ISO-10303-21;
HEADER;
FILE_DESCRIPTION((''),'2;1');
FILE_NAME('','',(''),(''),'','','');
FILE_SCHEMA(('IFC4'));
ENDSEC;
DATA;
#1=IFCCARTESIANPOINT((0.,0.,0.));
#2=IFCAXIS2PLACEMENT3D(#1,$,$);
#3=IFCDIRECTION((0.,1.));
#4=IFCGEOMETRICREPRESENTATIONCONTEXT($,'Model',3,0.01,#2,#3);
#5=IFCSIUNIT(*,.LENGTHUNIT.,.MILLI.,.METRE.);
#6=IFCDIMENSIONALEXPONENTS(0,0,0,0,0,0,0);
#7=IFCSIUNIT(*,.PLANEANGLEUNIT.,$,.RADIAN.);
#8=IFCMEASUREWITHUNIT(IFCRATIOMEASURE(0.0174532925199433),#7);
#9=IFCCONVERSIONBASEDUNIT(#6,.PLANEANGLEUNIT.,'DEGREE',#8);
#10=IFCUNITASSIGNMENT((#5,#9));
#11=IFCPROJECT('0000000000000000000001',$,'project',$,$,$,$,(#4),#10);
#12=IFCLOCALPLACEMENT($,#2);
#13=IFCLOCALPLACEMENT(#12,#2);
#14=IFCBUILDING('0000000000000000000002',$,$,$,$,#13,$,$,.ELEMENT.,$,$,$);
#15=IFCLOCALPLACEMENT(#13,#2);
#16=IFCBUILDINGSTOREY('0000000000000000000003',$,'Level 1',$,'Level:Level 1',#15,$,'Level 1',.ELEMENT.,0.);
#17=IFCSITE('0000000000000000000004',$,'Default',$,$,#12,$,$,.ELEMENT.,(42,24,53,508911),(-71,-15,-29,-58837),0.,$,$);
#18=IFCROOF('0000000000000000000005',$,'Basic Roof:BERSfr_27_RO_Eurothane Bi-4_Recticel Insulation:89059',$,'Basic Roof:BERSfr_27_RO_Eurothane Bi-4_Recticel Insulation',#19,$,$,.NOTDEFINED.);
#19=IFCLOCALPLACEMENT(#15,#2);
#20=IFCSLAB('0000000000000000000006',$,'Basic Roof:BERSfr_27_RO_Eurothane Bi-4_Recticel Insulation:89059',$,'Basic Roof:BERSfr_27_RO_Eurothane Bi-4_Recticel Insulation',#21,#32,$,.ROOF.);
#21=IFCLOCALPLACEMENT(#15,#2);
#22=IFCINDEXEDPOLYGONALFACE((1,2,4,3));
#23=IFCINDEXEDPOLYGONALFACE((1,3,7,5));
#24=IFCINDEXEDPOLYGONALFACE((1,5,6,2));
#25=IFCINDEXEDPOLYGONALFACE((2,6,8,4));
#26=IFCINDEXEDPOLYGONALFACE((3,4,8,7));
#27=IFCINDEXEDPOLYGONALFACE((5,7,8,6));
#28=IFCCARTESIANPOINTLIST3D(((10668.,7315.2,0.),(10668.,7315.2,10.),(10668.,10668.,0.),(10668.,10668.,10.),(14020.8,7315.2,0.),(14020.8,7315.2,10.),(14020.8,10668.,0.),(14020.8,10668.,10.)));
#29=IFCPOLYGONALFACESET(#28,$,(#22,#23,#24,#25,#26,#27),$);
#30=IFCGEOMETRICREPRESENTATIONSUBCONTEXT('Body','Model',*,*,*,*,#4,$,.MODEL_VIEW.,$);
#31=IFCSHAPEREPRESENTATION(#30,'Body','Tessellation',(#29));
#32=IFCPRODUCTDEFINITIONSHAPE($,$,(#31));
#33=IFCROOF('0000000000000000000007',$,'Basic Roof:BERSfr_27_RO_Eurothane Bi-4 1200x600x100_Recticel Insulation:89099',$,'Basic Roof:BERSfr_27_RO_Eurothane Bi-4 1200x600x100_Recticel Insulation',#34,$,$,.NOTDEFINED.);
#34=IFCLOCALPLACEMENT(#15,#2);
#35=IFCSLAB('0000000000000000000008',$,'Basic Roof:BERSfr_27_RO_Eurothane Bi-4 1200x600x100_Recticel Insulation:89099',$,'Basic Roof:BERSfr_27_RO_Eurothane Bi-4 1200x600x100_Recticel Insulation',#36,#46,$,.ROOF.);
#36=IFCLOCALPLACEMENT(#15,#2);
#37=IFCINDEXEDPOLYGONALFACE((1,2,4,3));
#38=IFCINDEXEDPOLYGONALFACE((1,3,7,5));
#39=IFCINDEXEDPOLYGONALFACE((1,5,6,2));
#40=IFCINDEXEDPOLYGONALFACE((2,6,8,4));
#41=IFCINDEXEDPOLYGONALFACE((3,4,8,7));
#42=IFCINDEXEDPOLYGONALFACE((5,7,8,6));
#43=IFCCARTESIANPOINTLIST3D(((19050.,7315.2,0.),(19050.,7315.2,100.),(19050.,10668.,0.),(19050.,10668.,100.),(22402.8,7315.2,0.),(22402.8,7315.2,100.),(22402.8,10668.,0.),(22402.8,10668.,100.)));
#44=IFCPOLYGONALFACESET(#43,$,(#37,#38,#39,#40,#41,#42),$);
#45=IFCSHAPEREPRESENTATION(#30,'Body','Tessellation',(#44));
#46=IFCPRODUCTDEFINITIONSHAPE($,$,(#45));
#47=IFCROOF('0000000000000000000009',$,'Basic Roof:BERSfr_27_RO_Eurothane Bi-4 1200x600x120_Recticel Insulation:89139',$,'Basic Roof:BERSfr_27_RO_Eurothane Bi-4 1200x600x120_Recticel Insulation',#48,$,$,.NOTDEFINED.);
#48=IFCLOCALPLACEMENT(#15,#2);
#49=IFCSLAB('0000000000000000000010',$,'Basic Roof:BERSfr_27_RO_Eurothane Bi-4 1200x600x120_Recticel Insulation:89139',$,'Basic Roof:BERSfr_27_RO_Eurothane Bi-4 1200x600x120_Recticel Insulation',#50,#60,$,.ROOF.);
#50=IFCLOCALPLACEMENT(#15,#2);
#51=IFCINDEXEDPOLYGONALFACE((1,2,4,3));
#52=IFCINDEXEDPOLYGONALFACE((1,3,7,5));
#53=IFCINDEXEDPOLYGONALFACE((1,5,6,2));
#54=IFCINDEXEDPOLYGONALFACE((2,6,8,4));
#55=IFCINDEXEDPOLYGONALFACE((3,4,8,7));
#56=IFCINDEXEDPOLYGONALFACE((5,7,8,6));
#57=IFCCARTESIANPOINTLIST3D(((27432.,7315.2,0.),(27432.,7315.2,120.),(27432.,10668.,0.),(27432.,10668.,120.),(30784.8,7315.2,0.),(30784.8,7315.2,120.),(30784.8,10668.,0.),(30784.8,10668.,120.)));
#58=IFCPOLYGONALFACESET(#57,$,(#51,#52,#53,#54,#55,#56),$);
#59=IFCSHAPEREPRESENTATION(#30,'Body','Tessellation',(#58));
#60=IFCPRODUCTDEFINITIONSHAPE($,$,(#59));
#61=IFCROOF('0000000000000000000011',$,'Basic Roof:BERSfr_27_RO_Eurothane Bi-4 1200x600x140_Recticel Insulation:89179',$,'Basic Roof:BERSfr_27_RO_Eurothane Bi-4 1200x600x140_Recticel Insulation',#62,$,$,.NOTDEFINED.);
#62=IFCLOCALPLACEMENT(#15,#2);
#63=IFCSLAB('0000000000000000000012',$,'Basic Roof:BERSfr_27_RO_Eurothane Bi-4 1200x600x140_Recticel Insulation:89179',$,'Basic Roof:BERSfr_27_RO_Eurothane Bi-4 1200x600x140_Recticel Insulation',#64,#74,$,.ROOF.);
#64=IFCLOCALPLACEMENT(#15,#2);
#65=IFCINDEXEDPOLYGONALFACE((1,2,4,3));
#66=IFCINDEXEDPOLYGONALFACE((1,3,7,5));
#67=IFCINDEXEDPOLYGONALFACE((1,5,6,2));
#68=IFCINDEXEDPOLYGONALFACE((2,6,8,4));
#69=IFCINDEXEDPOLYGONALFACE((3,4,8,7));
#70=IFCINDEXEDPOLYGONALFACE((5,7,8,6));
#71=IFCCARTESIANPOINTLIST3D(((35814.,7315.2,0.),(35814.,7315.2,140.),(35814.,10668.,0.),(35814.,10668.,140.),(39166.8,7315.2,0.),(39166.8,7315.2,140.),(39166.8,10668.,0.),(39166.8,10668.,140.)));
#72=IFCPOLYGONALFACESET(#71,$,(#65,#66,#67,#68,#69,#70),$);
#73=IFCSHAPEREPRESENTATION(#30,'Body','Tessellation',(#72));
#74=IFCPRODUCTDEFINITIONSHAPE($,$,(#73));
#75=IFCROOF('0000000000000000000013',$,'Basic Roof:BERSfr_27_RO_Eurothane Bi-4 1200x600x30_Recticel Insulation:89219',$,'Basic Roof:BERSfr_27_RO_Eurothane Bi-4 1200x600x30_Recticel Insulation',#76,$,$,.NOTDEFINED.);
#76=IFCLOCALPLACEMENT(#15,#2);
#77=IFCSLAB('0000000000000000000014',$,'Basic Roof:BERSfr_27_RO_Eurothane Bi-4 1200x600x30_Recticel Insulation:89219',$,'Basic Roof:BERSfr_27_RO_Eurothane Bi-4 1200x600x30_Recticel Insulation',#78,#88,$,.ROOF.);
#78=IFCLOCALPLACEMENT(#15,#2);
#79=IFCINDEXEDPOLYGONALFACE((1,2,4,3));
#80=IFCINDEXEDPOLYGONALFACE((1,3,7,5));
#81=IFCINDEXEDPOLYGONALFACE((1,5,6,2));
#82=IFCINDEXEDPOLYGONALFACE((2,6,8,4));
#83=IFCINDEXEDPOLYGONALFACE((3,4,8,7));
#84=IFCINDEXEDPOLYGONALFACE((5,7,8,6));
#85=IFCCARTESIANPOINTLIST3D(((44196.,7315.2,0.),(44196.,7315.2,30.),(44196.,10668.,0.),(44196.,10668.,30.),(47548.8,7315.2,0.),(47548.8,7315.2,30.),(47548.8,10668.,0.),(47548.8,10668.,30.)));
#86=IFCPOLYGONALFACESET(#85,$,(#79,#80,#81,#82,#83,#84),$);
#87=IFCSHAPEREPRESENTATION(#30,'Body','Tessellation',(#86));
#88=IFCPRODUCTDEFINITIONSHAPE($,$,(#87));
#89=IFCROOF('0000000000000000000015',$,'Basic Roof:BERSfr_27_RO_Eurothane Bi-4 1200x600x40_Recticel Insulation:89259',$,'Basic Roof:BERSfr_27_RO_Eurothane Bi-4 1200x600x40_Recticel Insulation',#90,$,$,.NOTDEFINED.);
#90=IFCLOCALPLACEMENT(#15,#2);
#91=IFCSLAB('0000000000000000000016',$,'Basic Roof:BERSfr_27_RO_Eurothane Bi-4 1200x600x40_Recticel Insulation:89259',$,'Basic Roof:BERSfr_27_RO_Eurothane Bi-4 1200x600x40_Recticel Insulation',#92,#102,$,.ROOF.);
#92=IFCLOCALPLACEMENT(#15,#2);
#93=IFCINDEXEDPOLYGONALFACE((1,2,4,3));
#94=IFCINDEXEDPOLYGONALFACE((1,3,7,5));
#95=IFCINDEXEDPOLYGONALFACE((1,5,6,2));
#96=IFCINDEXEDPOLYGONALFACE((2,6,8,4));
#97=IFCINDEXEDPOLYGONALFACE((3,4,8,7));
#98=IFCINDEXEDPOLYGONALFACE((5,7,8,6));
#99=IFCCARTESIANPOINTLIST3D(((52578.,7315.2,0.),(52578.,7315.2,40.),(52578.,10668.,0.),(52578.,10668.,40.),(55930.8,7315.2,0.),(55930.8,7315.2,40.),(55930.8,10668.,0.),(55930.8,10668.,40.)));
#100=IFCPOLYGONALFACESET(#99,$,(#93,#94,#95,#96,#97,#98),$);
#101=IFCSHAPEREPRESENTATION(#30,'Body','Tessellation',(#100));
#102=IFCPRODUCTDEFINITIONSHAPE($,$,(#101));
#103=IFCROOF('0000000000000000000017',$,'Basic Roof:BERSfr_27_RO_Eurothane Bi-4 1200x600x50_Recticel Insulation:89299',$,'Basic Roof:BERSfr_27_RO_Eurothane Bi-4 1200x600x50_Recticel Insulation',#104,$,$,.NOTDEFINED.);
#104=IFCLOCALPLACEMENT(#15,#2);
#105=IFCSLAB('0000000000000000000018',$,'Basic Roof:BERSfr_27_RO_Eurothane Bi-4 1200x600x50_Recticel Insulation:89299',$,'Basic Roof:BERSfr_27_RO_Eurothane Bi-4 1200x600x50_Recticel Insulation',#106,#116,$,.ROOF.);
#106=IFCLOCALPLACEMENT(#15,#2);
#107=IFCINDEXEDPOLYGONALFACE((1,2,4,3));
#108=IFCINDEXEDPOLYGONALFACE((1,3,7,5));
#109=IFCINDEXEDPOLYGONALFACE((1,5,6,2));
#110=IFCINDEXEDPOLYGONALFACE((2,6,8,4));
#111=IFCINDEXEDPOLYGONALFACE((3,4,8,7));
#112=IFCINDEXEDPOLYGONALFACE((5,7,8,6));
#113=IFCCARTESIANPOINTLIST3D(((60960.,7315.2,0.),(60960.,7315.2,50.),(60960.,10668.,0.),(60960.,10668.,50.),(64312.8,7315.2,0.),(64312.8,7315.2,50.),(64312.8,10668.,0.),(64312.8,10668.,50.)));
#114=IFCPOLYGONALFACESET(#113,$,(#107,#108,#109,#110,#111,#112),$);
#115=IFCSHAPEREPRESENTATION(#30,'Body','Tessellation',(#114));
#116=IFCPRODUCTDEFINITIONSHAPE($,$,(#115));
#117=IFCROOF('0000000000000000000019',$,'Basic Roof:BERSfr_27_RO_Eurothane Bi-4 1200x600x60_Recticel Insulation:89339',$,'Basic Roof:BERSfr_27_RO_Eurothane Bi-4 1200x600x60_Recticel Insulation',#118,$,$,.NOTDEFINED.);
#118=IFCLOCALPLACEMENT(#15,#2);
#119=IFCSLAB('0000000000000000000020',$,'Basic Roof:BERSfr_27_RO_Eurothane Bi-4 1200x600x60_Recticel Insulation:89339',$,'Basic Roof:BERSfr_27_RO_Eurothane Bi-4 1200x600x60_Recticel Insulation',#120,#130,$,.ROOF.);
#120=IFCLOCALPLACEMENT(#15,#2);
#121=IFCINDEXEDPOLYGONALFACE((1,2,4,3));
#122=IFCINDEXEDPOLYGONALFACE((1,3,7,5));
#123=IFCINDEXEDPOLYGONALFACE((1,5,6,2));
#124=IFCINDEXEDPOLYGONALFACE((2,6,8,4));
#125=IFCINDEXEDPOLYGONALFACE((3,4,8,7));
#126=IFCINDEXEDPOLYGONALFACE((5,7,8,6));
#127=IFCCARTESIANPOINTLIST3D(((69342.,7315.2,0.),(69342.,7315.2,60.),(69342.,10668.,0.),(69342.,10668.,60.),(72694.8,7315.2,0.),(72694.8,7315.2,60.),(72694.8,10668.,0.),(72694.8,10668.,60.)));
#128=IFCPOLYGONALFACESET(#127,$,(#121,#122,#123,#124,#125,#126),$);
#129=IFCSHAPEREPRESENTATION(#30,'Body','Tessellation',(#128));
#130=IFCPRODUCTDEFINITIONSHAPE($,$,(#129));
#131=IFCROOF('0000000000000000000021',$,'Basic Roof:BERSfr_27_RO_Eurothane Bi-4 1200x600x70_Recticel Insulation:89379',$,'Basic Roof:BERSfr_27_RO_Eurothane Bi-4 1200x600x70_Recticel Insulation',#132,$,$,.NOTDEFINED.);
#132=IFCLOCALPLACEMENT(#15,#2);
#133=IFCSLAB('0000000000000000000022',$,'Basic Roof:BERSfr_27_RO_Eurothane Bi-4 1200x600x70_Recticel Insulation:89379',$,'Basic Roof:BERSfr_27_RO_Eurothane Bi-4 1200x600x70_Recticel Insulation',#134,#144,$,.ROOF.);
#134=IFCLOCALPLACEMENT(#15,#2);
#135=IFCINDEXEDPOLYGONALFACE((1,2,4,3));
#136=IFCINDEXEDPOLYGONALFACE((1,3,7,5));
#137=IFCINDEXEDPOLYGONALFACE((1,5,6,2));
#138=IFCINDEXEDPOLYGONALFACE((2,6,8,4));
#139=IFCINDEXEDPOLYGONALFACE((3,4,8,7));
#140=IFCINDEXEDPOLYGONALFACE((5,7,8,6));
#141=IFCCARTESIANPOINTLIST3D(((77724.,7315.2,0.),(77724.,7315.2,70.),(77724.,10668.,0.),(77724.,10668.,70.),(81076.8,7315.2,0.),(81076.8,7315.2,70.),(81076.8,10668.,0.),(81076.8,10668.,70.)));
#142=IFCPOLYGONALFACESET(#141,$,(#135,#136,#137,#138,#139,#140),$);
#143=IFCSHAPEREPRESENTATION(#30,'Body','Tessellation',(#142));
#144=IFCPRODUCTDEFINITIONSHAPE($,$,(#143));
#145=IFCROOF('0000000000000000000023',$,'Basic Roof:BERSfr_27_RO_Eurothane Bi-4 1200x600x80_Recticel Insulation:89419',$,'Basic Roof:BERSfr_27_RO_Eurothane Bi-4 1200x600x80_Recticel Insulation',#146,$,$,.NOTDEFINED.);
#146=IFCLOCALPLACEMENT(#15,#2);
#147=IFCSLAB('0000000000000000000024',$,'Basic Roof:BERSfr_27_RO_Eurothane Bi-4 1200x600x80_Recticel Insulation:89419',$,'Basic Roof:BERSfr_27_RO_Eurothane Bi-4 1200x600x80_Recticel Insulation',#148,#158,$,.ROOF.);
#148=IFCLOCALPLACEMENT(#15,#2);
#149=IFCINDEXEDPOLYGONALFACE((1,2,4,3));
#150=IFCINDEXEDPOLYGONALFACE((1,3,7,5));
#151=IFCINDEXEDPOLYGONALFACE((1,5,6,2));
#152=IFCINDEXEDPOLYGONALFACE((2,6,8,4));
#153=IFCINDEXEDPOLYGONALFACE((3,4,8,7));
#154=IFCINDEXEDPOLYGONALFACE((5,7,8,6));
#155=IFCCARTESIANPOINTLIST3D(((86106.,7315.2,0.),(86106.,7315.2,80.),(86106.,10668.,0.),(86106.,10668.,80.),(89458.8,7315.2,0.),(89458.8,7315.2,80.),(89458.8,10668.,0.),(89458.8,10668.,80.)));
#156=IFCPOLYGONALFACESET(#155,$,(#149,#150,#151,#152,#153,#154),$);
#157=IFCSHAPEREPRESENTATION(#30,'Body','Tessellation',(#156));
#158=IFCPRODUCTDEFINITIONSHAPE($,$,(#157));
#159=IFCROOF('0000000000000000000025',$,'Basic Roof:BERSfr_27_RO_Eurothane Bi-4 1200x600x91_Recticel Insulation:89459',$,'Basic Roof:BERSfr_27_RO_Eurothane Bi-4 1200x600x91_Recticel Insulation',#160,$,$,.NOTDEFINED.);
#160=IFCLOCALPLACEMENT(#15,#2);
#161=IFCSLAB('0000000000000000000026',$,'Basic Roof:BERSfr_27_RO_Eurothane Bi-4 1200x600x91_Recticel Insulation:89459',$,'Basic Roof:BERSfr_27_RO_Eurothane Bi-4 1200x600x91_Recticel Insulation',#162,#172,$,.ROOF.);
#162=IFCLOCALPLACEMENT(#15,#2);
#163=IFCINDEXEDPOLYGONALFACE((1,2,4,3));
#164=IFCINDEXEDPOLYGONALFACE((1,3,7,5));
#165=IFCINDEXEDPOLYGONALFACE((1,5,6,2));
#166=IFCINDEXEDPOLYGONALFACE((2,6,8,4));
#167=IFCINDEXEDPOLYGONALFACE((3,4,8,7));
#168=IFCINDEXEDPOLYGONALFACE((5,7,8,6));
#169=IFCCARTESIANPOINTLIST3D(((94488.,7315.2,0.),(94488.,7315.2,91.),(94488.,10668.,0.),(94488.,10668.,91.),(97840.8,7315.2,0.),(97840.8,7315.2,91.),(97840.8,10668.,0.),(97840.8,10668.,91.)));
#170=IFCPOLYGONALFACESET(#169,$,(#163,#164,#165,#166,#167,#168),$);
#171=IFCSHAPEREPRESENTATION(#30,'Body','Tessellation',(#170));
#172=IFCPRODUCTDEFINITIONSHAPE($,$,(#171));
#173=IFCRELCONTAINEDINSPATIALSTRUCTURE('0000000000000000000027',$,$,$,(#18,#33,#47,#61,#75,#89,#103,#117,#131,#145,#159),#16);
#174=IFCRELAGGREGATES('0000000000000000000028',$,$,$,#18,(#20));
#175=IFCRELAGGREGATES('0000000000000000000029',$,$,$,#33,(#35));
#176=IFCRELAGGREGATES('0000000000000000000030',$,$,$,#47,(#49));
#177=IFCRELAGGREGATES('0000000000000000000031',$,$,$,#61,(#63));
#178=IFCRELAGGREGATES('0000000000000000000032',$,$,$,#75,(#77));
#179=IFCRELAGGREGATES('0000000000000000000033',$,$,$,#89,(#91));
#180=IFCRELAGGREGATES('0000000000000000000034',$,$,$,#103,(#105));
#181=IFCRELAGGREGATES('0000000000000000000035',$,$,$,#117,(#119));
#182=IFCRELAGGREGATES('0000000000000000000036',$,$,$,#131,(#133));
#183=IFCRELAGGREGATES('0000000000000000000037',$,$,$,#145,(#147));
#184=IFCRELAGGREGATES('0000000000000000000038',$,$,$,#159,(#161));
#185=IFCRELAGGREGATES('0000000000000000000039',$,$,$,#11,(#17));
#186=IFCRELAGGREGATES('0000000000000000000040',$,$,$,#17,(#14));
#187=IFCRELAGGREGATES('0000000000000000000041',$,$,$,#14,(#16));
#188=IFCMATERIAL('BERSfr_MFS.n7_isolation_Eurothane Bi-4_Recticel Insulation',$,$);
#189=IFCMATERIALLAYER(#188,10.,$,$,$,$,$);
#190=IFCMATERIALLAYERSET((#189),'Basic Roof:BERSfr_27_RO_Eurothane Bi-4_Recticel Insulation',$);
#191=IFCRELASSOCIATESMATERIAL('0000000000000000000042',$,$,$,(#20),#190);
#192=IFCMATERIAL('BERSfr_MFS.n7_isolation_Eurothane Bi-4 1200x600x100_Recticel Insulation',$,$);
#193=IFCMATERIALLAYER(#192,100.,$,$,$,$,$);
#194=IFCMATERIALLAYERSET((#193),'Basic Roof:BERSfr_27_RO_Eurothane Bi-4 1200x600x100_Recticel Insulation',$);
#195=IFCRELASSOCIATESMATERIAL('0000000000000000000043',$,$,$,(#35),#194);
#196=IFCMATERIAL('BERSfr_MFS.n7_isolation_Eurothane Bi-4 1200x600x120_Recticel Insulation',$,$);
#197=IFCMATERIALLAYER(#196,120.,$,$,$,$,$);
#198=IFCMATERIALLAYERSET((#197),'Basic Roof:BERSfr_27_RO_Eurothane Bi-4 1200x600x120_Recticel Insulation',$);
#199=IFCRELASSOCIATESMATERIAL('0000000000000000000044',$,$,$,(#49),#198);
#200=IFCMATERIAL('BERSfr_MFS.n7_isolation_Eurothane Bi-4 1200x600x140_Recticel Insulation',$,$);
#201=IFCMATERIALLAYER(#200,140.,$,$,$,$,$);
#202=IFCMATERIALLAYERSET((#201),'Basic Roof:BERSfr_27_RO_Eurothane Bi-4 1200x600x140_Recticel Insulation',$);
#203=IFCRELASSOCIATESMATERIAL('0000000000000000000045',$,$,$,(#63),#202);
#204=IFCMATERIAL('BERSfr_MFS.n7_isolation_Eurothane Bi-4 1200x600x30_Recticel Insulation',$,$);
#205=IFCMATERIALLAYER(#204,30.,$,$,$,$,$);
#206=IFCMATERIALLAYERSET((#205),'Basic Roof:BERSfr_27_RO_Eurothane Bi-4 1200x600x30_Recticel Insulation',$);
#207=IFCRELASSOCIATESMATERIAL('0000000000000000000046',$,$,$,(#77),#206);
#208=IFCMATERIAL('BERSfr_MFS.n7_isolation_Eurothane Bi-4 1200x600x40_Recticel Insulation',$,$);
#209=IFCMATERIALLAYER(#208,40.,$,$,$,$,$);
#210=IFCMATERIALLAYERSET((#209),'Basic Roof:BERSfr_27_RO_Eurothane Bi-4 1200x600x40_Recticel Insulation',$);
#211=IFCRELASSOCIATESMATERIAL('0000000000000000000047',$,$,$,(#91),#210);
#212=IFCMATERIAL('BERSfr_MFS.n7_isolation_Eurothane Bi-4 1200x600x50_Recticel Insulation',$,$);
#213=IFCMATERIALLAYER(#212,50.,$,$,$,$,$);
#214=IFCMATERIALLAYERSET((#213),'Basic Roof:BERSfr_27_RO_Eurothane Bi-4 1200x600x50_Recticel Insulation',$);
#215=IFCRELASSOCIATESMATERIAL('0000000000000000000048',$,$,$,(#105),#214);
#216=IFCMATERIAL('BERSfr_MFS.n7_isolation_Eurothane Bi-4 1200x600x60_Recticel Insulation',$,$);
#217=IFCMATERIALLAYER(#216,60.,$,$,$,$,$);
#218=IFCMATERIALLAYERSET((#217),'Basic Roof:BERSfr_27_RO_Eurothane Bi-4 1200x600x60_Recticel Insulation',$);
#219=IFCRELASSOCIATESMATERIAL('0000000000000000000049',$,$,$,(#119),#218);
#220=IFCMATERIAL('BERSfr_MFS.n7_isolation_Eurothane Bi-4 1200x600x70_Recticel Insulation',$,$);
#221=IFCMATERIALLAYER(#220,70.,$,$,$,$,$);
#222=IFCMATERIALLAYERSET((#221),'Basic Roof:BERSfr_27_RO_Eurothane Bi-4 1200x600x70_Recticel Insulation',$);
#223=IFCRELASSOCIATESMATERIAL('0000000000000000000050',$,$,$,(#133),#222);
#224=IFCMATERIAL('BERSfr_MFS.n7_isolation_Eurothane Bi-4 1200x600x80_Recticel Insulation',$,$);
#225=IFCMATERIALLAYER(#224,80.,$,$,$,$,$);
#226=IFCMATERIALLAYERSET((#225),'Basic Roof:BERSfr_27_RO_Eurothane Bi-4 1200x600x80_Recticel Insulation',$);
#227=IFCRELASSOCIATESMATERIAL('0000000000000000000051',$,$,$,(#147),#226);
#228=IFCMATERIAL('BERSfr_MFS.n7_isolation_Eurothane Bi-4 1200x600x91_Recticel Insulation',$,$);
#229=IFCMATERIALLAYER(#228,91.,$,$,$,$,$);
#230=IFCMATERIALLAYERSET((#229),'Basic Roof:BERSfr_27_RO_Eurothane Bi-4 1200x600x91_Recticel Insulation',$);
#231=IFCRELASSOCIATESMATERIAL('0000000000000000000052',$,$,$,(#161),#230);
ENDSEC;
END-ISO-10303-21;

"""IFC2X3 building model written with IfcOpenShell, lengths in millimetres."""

from ifc_helpers import new_model, entity, si_unit, converted_unit, direction, frame, frame_2d, origin, place, context, subcontext, project, spatial, rectangle, extrude, material, layer, layer_set, element, aggregate, save


model = new_model("IFC2X3")

# Units and contexts
model_context = context("Model", 3, precision=0.01, world=origin(), true_north=direction((0.0, 1.0)))
body_context = subcontext(model_context, "Body", "Model", "MODEL_VIEW")
ifc_project = project(units=[si_unit("LENGTHUNIT", "METRE", prefix="MILLI"), converted_unit("PLANEANGLEUNIT", "DEGREE", entity("IfcRatioMeasure", 0.0174532925199433), si_unit("PLANEANGLEUNIT", "RADIAN"), dimensions=[0, 0, 0, 0, 0, 0, 0])], contexts=[model_context])

# Site, building, storey
site_placement = place(None, origin())
site = spatial("IfcSite", under=ifc_project, at=site_placement, Name="Default", CompositionType="ELEMENT", RefLatitude=(42, 24, 53, 508911), RefLongitude=(-71, -15, -29, -58837), RefElevation=0.0)
building_placement = place(site_placement, origin())
building = spatial("IfcBuilding", under=site, at=building_placement, CompositionType="ELEMENT")
storey_placement = place(building_placement, origin())
storey = spatial("IfcBuildingStorey", under=building, at=storey_placement, Name="Level 1", ObjectType="Level:Level 1", LongName="Level 1", CompositionType="ELEMENT", Elevation=0.0)

# Roofs, slabs
roof_1_placement = place(storey_placement, frame((10668.0, 7315.2, 0.0)))
roof_1 = element("IfcRoof", 1, at=roof_1_placement, inside=storey, Name="Basic Roof:BERSfr_27_RO_Eurothane Bi-4_Recticel Insulation:89059", ObjectType="Basic Roof:BERSfr_27_RO_Eurothane Bi-4_Recticel Insulation", ShapeType="NOTDEFINED")
ifc_material_1 = material(Name="BERSfr_MFS.n7_isolation_Eurothane Bi-4_Recticel Insulation")
ifc_layer_1 = layer(ifc_material_1, 10.0)
ifc_layer_set_1 = layer_set([ifc_layer_1], Name="Basic Roof:BERSfr_27_RO_Eurothane Bi-4_Recticel Insulation")
slab_1_placement = place(roof_1_placement, origin())
slab_1 = element("IfcSlab", 2, at=slab_1_placement, material=ifc_layer_set_1, Name="Basic Roof:BERSfr_27_RO_Eurothane Bi-4_Recticel Insulation:89059", ObjectType="Basic Roof:BERSfr_27_RO_Eurothane Bi-4_Recticel Insulation", PredefinedType="ROOF", context=body_context, shape_type="SweptSolid", body=[
    extrude(rectangle(XDim=3352.8, YDim=3352.8, at=frame_2d((0.0, 0.0), x_axis=(-1.0, 0.0))), frame((1676.4, 1676.4, 0.0)), (0.0, 0.0, 1.0), 10.0),
])
aggregate(roof_1, [slab_1])
roof_2_placement = place(storey_placement, frame((19050.0, 7315.2, 0.0)))
roof_2 = element("IfcRoof", 3, at=roof_2_placement, inside=storey, Name="Basic Roof:BERSfr_27_RO_Eurothane Bi-4 1200x600x100_Recticel Insulation:89099", ObjectType="Basic Roof:BERSfr_27_RO_Eurothane Bi-4 1200x600x100_Recticel Insulation", ShapeType="NOTDEFINED")
ifc_material_2 = material(Name="BERSfr_MFS.n7_isolation_Eurothane Bi-4 1200x600x100_Recticel Insulation")
ifc_layer_2 = layer(ifc_material_2, 100.0)
ifc_layer_set_2 = layer_set([ifc_layer_2], Name="Basic Roof:BERSfr_27_RO_Eurothane Bi-4 1200x600x100_Recticel Insulation")
slab_2_placement = place(roof_2_placement, origin())
slab_2 = element("IfcSlab", 4, at=slab_2_placement, material=ifc_layer_set_2, Name="Basic Roof:BERSfr_27_RO_Eurothane Bi-4 1200x600x100_Recticel Insulation:89099", ObjectType="Basic Roof:BERSfr_27_RO_Eurothane Bi-4 1200x600x100_Recticel Insulation", PredefinedType="ROOF", context=body_context, shape_type="SweptSolid", body=[
    extrude(rectangle(XDim=3352.8, YDim=3352.8, at=frame_2d((0.0, 0.0), x_axis=(-1.0, 0.0))), frame((1676.4, 1676.4, 0.0)), (0.0, 0.0, 1.0), 100.0),
])
aggregate(roof_2, [slab_2])
roof_3_placement = place(storey_placement, frame((27432.0, 7315.2, 0.0)))
roof_3 = element("IfcRoof", 5, at=roof_3_placement, inside=storey, Name="Basic Roof:BERSfr_27_RO_Eurothane Bi-4 1200x600x120_Recticel Insulation:89139", ObjectType="Basic Roof:BERSfr_27_RO_Eurothane Bi-4 1200x600x120_Recticel Insulation", ShapeType="NOTDEFINED")
ifc_material_3 = material(Name="BERSfr_MFS.n7_isolation_Eurothane Bi-4 1200x600x120_Recticel Insulation")
ifc_layer_3 = layer(ifc_material_3, 120.0)
ifc_layer_set_3 = layer_set([ifc_layer_3], Name="Basic Roof:BERSfr_27_RO_Eurothane Bi-4 1200x600x120_Recticel Insulation")
slab_3_placement = place(roof_3_placement, origin())
slab_3 = element("IfcSlab", 6, at=slab_3_placement, material=ifc_layer_set_3, Name="Basic Roof:BERSfr_27_RO_Eurothane Bi-4 1200x600x120_Recticel Insulation:89139", ObjectType="Basic Roof:BERSfr_27_RO_Eurothane Bi-4 1200x600x120_Recticel Insulation", PredefinedType="ROOF", context=body_context, shape_type="SweptSolid", body=[
    extrude(rectangle(XDim=3352.8, YDim=3352.8, at=frame_2d((0.0, 0.0), x_axis=(-1.0, 0.0))), frame((1676.4, 1676.4, 0.0)), (0.0, 0.0, 1.0), 120.0),
])
aggregate(roof_3, [slab_3])
roof_4_placement = place(storey_placement, frame((35814.0, 7315.2, 0.0)))
roof_4 = element("IfcRoof", 7, at=roof_4_placement, inside=storey, Name="Basic Roof:BERSfr_27_RO_Eurothane Bi-4 1200x600x140_Recticel Insulation:89179", ObjectType="Basic Roof:BERSfr_27_RO_Eurothane Bi-4 1200x600x140_Recticel Insulation", ShapeType="NOTDEFINED")
ifc_material_4 = material(Name="BERSfr_MFS.n7_isolation_Eurothane Bi-4 1200x600x140_Recticel Insulation")
ifc_layer_4 = layer(ifc_material_4, 140.0)
ifc_layer_set_4 = layer_set([ifc_layer_4], Name="Basic Roof:BERSfr_27_RO_Eurothane Bi-4 1200x600x140_Recticel Insulation")
slab_4_placement = place(roof_4_placement, origin())
slab_4 = element("IfcSlab", 8, at=slab_4_placement, material=ifc_layer_set_4, Name="Basic Roof:BERSfr_27_RO_Eurothane Bi-4 1200x600x140_Recticel Insulation:89179", ObjectType="Basic Roof:BERSfr_27_RO_Eurothane Bi-4 1200x600x140_Recticel Insulation", PredefinedType="ROOF", context=body_context, shape_type="SweptSolid", body=[
    extrude(rectangle(XDim=3352.8, YDim=3352.8, at=frame_2d((0.0, 0.0), x_axis=(-1.0, 0.0))), frame((1676.4, 1676.4, 0.0)), (0.0, 0.0, 1.0), 140.0),
])
aggregate(roof_4, [slab_4])
roof_5_placement = place(storey_placement, frame((44196.0, 7315.2, 0.0)))
roof_5 = element("IfcRoof", 9, at=roof_5_placement, inside=storey, Name="Basic Roof:BERSfr_27_RO_Eurothane Bi-4 1200x600x30_Recticel Insulation:89219", ObjectType="Basic Roof:BERSfr_27_RO_Eurothane Bi-4 1200x600x30_Recticel Insulation", ShapeType="NOTDEFINED")
ifc_material_5 = material(Name="BERSfr_MFS.n7_isolation_Eurothane Bi-4 1200x600x30_Recticel Insulation")
ifc_layer_5 = layer(ifc_material_5, 30.0)
ifc_layer_set_5 = layer_set([ifc_layer_5], Name="Basic Roof:BERSfr_27_RO_Eurothane Bi-4 1200x600x30_Recticel Insulation")
slab_5_placement = place(roof_5_placement, origin())
slab_5 = element("IfcSlab", 10, at=slab_5_placement, material=ifc_layer_set_5, Name="Basic Roof:BERSfr_27_RO_Eurothane Bi-4 1200x600x30_Recticel Insulation:89219", ObjectType="Basic Roof:BERSfr_27_RO_Eurothane Bi-4 1200x600x30_Recticel Insulation", PredefinedType="ROOF", context=body_context, shape_type="SweptSolid", body=[
    extrude(rectangle(XDim=3352.8, YDim=3352.8, at=frame_2d((0.0, 0.0), x_axis=(-1.0, 0.0))), frame((1676.4, 1676.4, 0.0)), (0.0, 0.0, 1.0), 30.0),
])
aggregate(roof_5, [slab_5])
roof_6_placement = place(storey_placement, frame((52578.0, 7315.2, 0.0)))
roof_6 = element("IfcRoof", 11, at=roof_6_placement, inside=storey, Name="Basic Roof:BERSfr_27_RO_Eurothane Bi-4 1200x600x40_Recticel Insulation:89259", ObjectType="Basic Roof:BERSfr_27_RO_Eurothane Bi-4 1200x600x40_Recticel Insulation", ShapeType="NOTDEFINED")
ifc_material_6 = material(Name="BERSfr_MFS.n7_isolation_Eurothane Bi-4 1200x600x40_Recticel Insulation")
ifc_layer_6 = layer(ifc_material_6, 40.0)
ifc_layer_set_6 = layer_set([ifc_layer_6], Name="Basic Roof:BERSfr_27_RO_Eurothane Bi-4 1200x600x40_Recticel Insulation")
slab_6_placement = place(roof_6_placement, origin())
slab_6 = element("IfcSlab", 12, at=slab_6_placement, material=ifc_layer_set_6, Name="Basic Roof:BERSfr_27_RO_Eurothane Bi-4 1200x600x40_Recticel Insulation:89259", ObjectType="Basic Roof:BERSfr_27_RO_Eurothane Bi-4 1200x600x40_Recticel Insulation", PredefinedType="ROOF", context=body_context, shape_type="SweptSolid", body=[
    extrude(rectangle(XDim=3352.8, YDim=3352.8, at=frame_2d((0.0, 0.0), x_axis=(-1.0, 0.0))), frame((1676.4, 1676.4, 0.0)), (0.0, 0.0, 1.0), 40.0),
])
aggregate(roof_6, [slab_6])
roof_7_placement = place(storey_placement, frame((60960.0, 7315.2, 0.0)))
roof_7 = element("IfcRoof", 13, at=roof_7_placement, inside=storey, Name="Basic Roof:BERSfr_27_RO_Eurothane Bi-4 1200x600x50_Recticel Insulation:89299", ObjectType="Basic Roof:BERSfr_27_RO_Eurothane Bi-4 1200x600x50_Recticel Insulation", ShapeType="NOTDEFINED")
ifc_material_7 = material(Name="BERSfr_MFS.n7_isolation_Eurothane Bi-4 1200x600x50_Recticel Insulation")
ifc_layer_7 = layer(ifc_material_7, 50.0)
ifc_layer_set_7 = layer_set([ifc_layer_7], Name="Basic Roof:BERSfr_27_RO_Eurothane Bi-4 1200x600x50_Recticel Insulation")
slab_7_placement = place(roof_7_placement, origin())
slab_7 = element("IfcSlab", 14, at=slab_7_placement, material=ifc_layer_set_7, Name="Basic Roof:BERSfr_27_RO_Eurothane Bi-4 1200x600x50_Recticel Insulation:89299", ObjectType="Basic Roof:BERSfr_27_RO_Eurothane Bi-4 1200x600x50_Recticel Insulation", PredefinedType="ROOF", context=body_context, shape_type="SweptSolid", body=[
    extrude(rectangle(XDim=3352.8, YDim=3352.8, at=frame_2d((0.0, 0.0), x_axis=(-1.0, 0.0))), frame((1676.4, 1676.4, 0.0)), (0.0, 0.0, 1.0), 50.0),
])
aggregate(roof_7, [slab_7])
roof_8_placement = place(storey_placement, frame((69342.0, 7315.2, 0.0)))
roof_8 = element("IfcRoof", 15, at=roof_8_placement, inside=storey, Name="Basic Roof:BERSfr_27_RO_Eurothane Bi-4 1200x600x60_Recticel Insulation:89339", ObjectType="Basic Roof:BERSfr_27_RO_Eurothane Bi-4 1200x600x60_Recticel Insulation", ShapeType="NOTDEFINED")
ifc_material_8 = material(Name="BERSfr_MFS.n7_isolation_Eurothane Bi-4 1200x600x60_Recticel Insulation")
ifc_layer_8 = layer(ifc_material_8, 60.0)
ifc_layer_set_8 = layer_set([ifc_layer_8], Name="Basic Roof:BERSfr_27_RO_Eurothane Bi-4 1200x600x60_Recticel Insulation")
slab_8_placement = place(roof_8_placement, origin())
slab_8 = element("IfcSlab", 16, at=slab_8_placement, material=ifc_layer_set_8, Name="Basic Roof:BERSfr_27_RO_Eurothane Bi-4 1200x600x60_Recticel Insulation:89339", ObjectType="Basic Roof:BERSfr_27_RO_Eurothane Bi-4 1200x600x60_Recticel Insulation", PredefinedType="ROOF", context=body_context, shape_type="SweptSolid", body=[
    extrude(rectangle(XDim=3352.8, YDim=3352.8, at=frame_2d((0.0, 0.0), x_axis=(-1.0, 0.0))), frame((1676.4, 1676.4, 0.0)), (0.0, 0.0, 1.0), 60.0),
])
aggregate(roof_8, [slab_8])
roof_9_placement = place(storey_placement, frame((77724.0, 7315.2, 0.0)))
roof_9 = element("IfcRoof", 17, at=roof_9_placement, inside=storey, Name="Basic Roof:BERSfr_27_RO_Eurothane Bi-4 1200x600x70_Recticel Insulation:89379", ObjectType="Basic Roof:BERSfr_27_RO_Eurothane Bi-4 1200x600x70_Recticel Insulation", ShapeType="NOTDEFINED")
ifc_material_9 = material(Name="BERSfr_MFS.n7_isolation_Eurothane Bi-4 1200x600x70_Recticel Insulation")
ifc_layer_9 = layer(ifc_material_9, 70.0)
ifc_layer_set_9 = layer_set([ifc_layer_9], Name="Basic Roof:BERSfr_27_RO_Eurothane Bi-4 1200x600x70_Recticel Insulation")
slab_9_placement = place(roof_9_placement, origin())
slab_9 = element("IfcSlab", 18, at=slab_9_placement, material=ifc_layer_set_9, Name="Basic Roof:BERSfr_27_RO_Eurothane Bi-4 1200x600x70_Recticel Insulation:89379", ObjectType="Basic Roof:BERSfr_27_RO_Eurothane Bi-4 1200x600x70_Recticel Insulation", PredefinedType="ROOF", context=body_context, shape_type="SweptSolid", body=[
    extrude(rectangle(XDim=3352.8, YDim=3352.8, at=frame_2d((0.0, 0.0), x_axis=(-1.0, 0.0))), frame((1676.4, 1676.4, 0.0)), (0.0, 0.0, 1.0), 70.0),
])
aggregate(roof_9, [slab_9])
roof_10_placement = place(storey_placement, frame((86106.0, 7315.2, 0.0)))
roof_10 = element("IfcRoof", 19, at=roof_10_placement, inside=storey, Name="Basic Roof:BERSfr_27_RO_Eurothane Bi-4 1200x600x80_Recticel Insulation:89419", ObjectType="Basic Roof:BERSfr_27_RO_Eurothane Bi-4 1200x600x80_Recticel Insulation", ShapeType="NOTDEFINED")
ifc_material_10 = material(Name="BERSfr_MFS.n7_isolation_Eurothane Bi-4 1200x600x80_Recticel Insulation")
ifc_layer_10 = layer(ifc_material_10, 80.0)
ifc_layer_set_10 = layer_set([ifc_layer_10], Name="Basic Roof:BERSfr_27_RO_Eurothane Bi-4 1200x600x80_Recticel Insulation")
slab_10_placement = place(roof_10_placement, origin())
slab_10 = element("IfcSlab", 20, at=slab_10_placement, material=ifc_layer_set_10, Name="Basic Roof:BERSfr_27_RO_Eurothane Bi-4 1200x600x80_Recticel Insulation:89419", ObjectType="Basic Roof:BERSfr_27_RO_Eurothane Bi-4 1200x600x80_Recticel Insulation", PredefinedType="ROOF", context=body_context, shape_type="SweptSolid", body=[
    extrude(rectangle(XDim=3352.8, YDim=3352.8, at=frame_2d((0.0, 0.0), x_axis=(-1.0, 0.0))), frame((1676.4, 1676.4, 0.0)), (0.0, 0.0, 1.0), 80.0),
])
aggregate(roof_10, [slab_10])
roof_11_placement = place(storey_placement, frame((94488.0, 7315.2, 0.0)))
roof_11 = element("IfcRoof", 21, at=roof_11_placement, inside=storey, Name="Basic Roof:BERSfr_27_RO_Eurothane Bi-4 1200x600x91_Recticel Insulation:89459", ObjectType="Basic Roof:BERSfr_27_RO_Eurothane Bi-4 1200x600x91_Recticel Insulation", ShapeType="NOTDEFINED")
ifc_material_11 = material(Name="BERSfr_MFS.n7_isolation_Eurothane Bi-4 1200x600x91_Recticel Insulation")
ifc_layer_11 = layer(ifc_material_11, 91.0)
ifc_layer_set_11 = layer_set([ifc_layer_11], Name="Basic Roof:BERSfr_27_RO_Eurothane Bi-4 1200x600x91_Recticel Insulation")
slab_11_placement = place(roof_11_placement, origin())
slab_11 = element("IfcSlab", 22, at=slab_11_placement, material=ifc_layer_set_11, Name="Basic Roof:BERSfr_27_RO_Eurothane Bi-4 1200x600x91_Recticel Insulation:89459", ObjectType="Basic Roof:BERSfr_27_RO_Eurothane Bi-4 1200x600x91_Recticel Insulation", PredefinedType="ROOF", context=body_context, shape_type="SweptSolid", body=[
    extrude(rectangle(XDim=3352.8, YDim=3352.8, at=frame_2d((0.0, 0.0), x_axis=(-1.0, 0.0))), frame((1676.4, 1676.4, 0.0)), (0.0, 0.0, 1.0), 91.0),
])
aggregate(roof_11, [slab_11])

save(model, "model.ifc")
